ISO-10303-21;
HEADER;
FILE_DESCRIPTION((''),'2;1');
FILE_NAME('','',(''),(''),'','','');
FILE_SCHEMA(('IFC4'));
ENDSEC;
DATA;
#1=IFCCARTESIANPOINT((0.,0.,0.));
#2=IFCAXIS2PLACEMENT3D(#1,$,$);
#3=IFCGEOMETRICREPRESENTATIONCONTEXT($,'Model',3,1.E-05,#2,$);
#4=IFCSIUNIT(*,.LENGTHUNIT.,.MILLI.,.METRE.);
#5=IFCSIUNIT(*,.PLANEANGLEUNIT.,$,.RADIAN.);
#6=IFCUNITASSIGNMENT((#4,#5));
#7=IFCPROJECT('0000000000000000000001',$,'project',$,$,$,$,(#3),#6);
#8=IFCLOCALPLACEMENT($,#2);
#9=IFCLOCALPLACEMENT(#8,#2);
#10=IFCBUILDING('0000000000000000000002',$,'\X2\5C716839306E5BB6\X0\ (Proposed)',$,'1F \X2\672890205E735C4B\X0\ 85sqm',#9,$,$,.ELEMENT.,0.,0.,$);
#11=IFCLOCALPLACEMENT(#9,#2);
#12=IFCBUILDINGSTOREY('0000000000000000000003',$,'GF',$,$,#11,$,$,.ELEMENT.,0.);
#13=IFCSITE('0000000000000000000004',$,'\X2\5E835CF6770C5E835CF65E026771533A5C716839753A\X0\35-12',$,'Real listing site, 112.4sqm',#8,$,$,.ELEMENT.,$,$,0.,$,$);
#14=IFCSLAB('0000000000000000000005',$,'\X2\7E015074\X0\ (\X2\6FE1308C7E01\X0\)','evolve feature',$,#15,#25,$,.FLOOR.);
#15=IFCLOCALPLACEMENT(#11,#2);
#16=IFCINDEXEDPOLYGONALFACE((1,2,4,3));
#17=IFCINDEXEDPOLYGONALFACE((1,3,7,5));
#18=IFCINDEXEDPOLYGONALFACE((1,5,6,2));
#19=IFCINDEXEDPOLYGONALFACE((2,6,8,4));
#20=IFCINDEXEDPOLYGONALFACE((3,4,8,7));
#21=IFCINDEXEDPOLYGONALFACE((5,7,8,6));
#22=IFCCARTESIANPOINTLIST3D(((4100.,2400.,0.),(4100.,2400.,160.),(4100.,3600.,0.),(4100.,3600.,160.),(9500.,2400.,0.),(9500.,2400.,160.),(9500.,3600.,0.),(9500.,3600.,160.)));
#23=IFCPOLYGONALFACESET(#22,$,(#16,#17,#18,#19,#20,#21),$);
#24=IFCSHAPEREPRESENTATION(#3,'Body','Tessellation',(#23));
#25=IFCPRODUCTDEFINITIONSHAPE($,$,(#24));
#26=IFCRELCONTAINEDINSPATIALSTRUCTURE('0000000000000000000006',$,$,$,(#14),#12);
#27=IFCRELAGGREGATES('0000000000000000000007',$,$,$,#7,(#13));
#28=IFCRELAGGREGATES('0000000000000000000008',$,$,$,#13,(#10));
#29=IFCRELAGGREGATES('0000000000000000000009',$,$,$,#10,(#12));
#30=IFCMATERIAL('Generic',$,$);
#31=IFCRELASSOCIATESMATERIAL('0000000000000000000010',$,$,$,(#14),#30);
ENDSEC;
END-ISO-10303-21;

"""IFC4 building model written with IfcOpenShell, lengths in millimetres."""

from ifc_helpers import new_model, si_unit, frame, frame_2d, origin, place, context, project, spatial, rectangle, extrude, material, element, save


model = new_model("IFC4")

# Units and contexts
model_context = context("Model", 3, precision=1e-05, world=origin())
ifc_project = project(units=[si_unit("LENGTHUNIT", "METRE", prefix="MILLI"), si_unit("PLANEANGLEUNIT", "RADIAN")], contexts=[model_context])

# Site, building, storey
site_placement = place(None, origin())
site = spatial("IfcSite", under=ifc_project, at=site_placement, Name="広島県広島市東区山根町35-12", ObjectType="Real listing site, 112.4sqm", CompositionType="ELEMENT", RefElevation=0.0)
building_placement = place(site_placement, origin())
building = spatial("IfcBuilding", under=site, at=building_placement, Name="山根の家 (Proposed)", ObjectType="1F 木造平屋 85sqm", CompositionType="ELEMENT", ElevationOfRefHeight=0.0, ElevationOfTerrain=0.0)
storey_placement = place(building_placement, origin())
storey = spatial("IfcBuildingStorey", under=building, at=storey_placement, Name="GF", CompositionType="ELEMENT", Elevation=0.0)

# Slab
ifc_material_1 = material(Name="Generic")
slab_1_placement = place(storey_placement, frame((2050.0, 1200.0, 0.0)))
element("IfcSlab", 1, at=slab_1_placement, inside=storey, material=ifc_material_1, Name="縁側 (濡れ縁)", Description="evolve feature", PredefinedType="FLOOR", context=model_context, shape_type="SweptSolid", body=[
    extrude(rectangle(XDim=5400.0, YDim=1200.0, at=frame_2d((2700.0, 600.0))), frame((2050.0, 1200.0, 0.0)), (0.0, 0.0, 1.0), 160.0),
])

save(model, "model.ifc")
